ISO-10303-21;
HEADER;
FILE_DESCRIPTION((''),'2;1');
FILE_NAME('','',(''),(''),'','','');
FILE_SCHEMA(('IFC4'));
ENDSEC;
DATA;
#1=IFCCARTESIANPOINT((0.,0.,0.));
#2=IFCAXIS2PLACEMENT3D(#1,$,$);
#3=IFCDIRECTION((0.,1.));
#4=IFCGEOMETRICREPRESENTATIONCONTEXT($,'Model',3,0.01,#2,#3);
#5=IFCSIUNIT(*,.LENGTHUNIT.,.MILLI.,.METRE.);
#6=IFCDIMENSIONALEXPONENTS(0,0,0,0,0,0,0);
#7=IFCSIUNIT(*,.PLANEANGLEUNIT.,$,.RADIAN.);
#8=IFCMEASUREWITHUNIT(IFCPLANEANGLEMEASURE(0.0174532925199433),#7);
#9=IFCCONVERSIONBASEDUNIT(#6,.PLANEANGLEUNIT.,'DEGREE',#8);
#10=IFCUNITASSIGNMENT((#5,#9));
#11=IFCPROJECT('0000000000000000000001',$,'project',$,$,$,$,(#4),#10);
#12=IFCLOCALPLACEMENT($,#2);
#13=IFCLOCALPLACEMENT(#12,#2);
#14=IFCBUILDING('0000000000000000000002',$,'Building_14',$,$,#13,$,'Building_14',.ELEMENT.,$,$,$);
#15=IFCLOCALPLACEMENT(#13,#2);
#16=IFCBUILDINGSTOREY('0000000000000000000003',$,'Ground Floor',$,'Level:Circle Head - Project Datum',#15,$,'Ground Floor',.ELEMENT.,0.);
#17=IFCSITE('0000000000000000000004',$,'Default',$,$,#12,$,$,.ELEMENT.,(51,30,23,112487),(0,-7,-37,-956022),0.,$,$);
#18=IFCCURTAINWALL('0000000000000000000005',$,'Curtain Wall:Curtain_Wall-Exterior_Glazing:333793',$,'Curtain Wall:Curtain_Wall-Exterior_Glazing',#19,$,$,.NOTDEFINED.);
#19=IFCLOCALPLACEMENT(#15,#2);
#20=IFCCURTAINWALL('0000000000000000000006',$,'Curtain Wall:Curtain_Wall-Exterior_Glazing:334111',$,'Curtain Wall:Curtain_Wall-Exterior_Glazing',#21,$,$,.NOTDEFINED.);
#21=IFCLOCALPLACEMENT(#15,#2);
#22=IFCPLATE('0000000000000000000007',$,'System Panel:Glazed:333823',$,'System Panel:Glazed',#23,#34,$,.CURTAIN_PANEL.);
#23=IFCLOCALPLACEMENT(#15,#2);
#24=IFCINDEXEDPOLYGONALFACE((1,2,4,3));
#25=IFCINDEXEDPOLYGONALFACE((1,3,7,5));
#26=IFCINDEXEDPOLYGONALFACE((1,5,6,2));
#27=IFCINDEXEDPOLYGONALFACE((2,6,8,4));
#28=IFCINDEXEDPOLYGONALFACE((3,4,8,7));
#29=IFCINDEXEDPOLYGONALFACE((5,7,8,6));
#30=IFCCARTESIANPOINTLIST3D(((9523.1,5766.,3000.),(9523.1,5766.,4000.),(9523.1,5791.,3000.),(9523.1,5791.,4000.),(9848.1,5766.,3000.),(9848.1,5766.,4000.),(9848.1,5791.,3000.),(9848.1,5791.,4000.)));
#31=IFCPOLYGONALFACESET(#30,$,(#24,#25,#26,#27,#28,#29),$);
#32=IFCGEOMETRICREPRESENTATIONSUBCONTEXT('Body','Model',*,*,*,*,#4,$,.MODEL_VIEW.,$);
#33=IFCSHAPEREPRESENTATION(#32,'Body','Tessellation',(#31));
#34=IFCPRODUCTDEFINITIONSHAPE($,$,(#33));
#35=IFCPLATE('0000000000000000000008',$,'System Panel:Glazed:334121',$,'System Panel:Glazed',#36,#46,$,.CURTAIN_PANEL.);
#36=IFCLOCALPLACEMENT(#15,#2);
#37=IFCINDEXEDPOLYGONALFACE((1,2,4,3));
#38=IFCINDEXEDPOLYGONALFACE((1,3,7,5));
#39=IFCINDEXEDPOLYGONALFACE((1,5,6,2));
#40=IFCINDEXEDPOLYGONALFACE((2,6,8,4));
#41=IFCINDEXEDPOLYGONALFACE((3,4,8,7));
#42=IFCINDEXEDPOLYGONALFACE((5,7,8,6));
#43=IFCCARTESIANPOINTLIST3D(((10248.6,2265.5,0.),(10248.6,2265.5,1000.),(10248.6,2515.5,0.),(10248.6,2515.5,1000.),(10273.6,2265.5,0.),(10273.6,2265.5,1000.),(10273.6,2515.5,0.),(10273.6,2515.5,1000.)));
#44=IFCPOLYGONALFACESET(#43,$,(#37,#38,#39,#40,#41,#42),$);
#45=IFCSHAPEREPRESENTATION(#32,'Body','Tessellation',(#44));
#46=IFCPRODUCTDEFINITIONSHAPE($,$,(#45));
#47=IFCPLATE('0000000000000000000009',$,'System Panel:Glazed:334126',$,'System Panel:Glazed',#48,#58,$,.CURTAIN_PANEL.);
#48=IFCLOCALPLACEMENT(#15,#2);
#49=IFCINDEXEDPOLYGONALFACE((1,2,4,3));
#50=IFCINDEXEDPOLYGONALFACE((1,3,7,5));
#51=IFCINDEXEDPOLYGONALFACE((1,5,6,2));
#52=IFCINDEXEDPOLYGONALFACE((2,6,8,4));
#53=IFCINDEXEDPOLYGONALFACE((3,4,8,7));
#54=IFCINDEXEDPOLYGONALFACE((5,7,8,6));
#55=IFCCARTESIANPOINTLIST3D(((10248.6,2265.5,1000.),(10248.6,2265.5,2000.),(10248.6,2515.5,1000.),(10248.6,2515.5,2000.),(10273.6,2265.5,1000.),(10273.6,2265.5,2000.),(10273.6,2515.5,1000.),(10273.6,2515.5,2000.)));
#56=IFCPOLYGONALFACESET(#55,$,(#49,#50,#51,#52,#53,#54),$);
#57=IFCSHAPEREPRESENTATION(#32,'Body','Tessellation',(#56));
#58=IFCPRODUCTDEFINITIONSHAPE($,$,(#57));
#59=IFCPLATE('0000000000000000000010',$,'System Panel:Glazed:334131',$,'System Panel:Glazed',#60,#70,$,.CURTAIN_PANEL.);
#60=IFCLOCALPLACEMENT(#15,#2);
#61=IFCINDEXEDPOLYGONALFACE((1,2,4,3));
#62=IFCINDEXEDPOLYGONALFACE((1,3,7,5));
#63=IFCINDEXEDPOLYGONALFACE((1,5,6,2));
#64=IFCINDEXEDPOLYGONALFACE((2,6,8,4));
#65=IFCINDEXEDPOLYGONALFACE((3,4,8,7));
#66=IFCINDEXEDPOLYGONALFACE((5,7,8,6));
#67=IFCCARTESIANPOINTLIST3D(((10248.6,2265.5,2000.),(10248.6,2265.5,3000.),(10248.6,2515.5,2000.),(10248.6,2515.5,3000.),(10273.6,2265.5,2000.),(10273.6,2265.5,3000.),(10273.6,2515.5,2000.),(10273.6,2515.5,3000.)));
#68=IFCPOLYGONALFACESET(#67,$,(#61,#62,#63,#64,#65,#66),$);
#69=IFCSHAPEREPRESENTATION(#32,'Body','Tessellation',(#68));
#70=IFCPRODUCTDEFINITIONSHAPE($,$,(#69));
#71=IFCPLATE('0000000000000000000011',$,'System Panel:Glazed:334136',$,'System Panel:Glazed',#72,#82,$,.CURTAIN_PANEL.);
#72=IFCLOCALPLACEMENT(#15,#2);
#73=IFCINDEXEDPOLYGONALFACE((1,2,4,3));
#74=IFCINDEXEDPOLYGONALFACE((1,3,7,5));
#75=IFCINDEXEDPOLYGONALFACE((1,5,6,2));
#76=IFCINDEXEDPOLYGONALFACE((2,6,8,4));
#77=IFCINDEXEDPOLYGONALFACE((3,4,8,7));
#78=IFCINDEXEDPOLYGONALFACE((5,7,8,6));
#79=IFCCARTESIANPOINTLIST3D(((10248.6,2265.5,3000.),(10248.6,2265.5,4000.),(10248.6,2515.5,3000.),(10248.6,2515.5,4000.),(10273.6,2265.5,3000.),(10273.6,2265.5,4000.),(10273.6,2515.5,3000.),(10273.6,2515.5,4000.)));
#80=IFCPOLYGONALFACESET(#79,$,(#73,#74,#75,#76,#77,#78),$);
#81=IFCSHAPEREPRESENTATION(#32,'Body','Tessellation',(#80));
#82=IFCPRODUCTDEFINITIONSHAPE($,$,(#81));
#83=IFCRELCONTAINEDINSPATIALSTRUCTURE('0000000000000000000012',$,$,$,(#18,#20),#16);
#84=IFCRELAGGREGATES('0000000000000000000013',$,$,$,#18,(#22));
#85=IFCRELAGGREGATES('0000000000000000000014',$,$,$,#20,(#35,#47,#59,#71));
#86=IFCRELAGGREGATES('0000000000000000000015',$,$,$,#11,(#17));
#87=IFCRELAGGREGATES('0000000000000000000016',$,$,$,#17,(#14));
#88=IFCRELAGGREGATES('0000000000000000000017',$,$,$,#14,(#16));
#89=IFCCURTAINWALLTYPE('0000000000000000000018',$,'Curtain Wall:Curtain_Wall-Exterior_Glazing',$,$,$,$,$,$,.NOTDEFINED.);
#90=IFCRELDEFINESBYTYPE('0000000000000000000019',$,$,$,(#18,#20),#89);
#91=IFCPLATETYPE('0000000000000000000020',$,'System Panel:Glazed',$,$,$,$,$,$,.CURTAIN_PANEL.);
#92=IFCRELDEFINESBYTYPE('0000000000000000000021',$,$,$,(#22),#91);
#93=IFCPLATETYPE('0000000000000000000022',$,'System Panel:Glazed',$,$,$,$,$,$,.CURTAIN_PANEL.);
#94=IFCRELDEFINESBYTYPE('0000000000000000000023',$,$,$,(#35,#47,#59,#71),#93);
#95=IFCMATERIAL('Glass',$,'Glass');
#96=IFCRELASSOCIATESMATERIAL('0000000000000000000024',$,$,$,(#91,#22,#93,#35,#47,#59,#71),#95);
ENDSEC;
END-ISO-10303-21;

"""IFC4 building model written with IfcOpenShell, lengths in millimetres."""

from ifc_helpers import new_model, entity, si_unit, converted_unit, direction, frame, origin, place, context, subcontext, project, spatial, indexed_curve, outline, extrude, source, transform, mapped, material, type_object, type_shapes, element, aggregate, save


model = new_model("IFC4")

# Units and contexts
model_context = context("Model", 3, precision=0.01, world=origin(), true_north=direction((0.0, 1.0)))
body_context = subcontext(model_context, "Body", "Model", "MODEL_VIEW")
ifc_project = project(units=[si_unit("LENGTHUNIT", "METRE", prefix="MILLI"), converted_unit("PLANEANGLEUNIT", "DEGREE", entity("IfcPlaneAngleMeasure", 0.0174532925199433), si_unit("PLANEANGLEUNIT", "RADIAN"), dimensions=[0, 0, 0, 0, 0, 0, 0])], contexts=[model_context])

# Site, building, storey
site_placement = place(None, origin())
site = spatial("IfcSite", under=ifc_project, at=site_placement, Name="Default", CompositionType="ELEMENT", RefLatitude=(51, 30, 23, 112487), RefLongitude=(0, -7, -37, -956022), RefElevation=0.0)
building_placement = place(site_placement, origin())
building = spatial("IfcBuilding", under=site, at=building_placement, Name="Building_14", LongName="Building_14", CompositionType="ELEMENT")
storey_placement = place(building_placement, origin())
storey = spatial("IfcBuildingStorey", under=building, at=storey_placement, Name="Ground Floor", ObjectType="Level:Circle Head - Project Datum", LongName="Ground Floor", CompositionType="ELEMENT", Elevation=0.0)

# Curtain walls
curtain_wall_type = type_object("IfcCurtainWallType", Name="Curtain Wall:Curtain_Wall-Exterior_Glazing", PredefinedType="NOTDEFINED")
curtain_wall_1_placement = place(storey_placement, origin())
curtain_wall_1 = element("IfcCurtainWall", 1, at=curtain_wall_1_placement, inside=storey, type_object=curtain_wall_type, Name="Curtain Wall:Curtain_Wall-Exterior_Glazing:333793", ObjectType="Curtain Wall:Curtain_Wall-Exterior_Glazing", PredefinedType="NOTDEFINED")
ifc_material = material(Name="Glass", Category="Glass")
curtain_wall_2_placement = place(storey_placement, origin())
curtain_wall_2 = element("IfcCurtainWall", 2, at=curtain_wall_2_placement, inside=storey, type_object=curtain_wall_type, Name="Curtain Wall:Curtain_Wall-Exterior_Glazing:334111", ObjectType="Curtain Wall:Curtain_Wall-Exterior_Glazing", PredefinedType="NOTDEFINED")

# Plates
plate_type_1 = type_object("IfcPlateType", Name="System Panel:Glazed", PredefinedType="CURTAIN_PANEL", material=ifc_material)
shared_shape_1 = source(origin(), body_context, "Body", "SweptSolid", [
    extrude(outline(indexed_curve([(-12.5, -162.5), (12.5, -162.5), (12.5, 162.5), (-12.5, 162.5), (-12.5, -162.5)], self_intersect=False)), frame((0.0, -37.0, 0.0), z_axis=(0.0, 0.0, 1.0), x_axis=(0.0, 1.0, 0.0)), (0.0, 0.0, 1.0), 1000.0),
])
type_shapes(plate_type_1, [shared_shape_1])
plate_1_placement = place(curtain_wall_1_placement, frame((9685.6, 5815.5, 3000.0)))
plate_1 = element("IfcPlate", 3, at=plate_1_placement, type_object=plate_type_1, material=ifc_material, Name="System Panel:Glazed:333823", ObjectType="System Panel:Glazed", PredefinedType="CURTAIN_PANEL", context=body_context, shape_type="MappedRepresentation", body=[
    mapped(shared_shape_1, transform((0.0, 0.0, 0.0), scale=1.0)),
])
aggregate(curtain_wall_1, [plate_1])
plate_type_2 = type_object("IfcPlateType", Name="System Panel:Glazed", PredefinedType="CURTAIN_PANEL", material=ifc_material)
shared_shape_2 = source(origin(), body_context, "Body", "SweptSolid", [
    extrude(outline(indexed_curve([(-12.5, -125.0), (12.5, -125.0), (12.5, 125.0), (-12.5, 125.0), (-12.5, -125.0)], self_intersect=False)), frame((0.0, -37.0, 0.0), z_axis=(0.0, 0.0, 1.0), x_axis=(0.0, 1.0, 0.0)), (0.0, 0.0, 1.0), 1000.0),
])
type_shapes(plate_type_2, [shared_shape_2])
plate_2_placement = place(curtain_wall_2_placement, frame((10298.1, 2390.5, 0.0), z_axis=(0.0, 0.0, 1.0), x_axis=(0.0, -1.0, 0.0)))
plate_2 = element("IfcPlate", 4, at=plate_2_placement, type_object=plate_type_2, material=ifc_material, Name="System Panel:Glazed:334121", ObjectType="System Panel:Glazed", PredefinedType="CURTAIN_PANEL", context=body_context, shape_type="MappedRepresentation", body=[
    mapped(shared_shape_2, transform((0.0, 0.0, 0.0), scale=1.0)),
])
plate_3_placement = place(curtain_wall_2_placement, frame((10298.1, 2390.5, 1000.0), z_axis=(0.0, 0.0, 1.0), x_axis=(0.0, -1.0, 0.0)))
plate_3 = element("IfcPlate", 5, at=plate_3_placement, type_object=plate_type_2, material=ifc_material, Name="System Panel:Glazed:334126", ObjectType="System Panel:Glazed", PredefinedType="CURTAIN_PANEL", context=body_context, shape_type="MappedRepresentation", body=[
    mapped(shared_shape_2, transform((0.0, 0.0, 0.0), scale=1.0)),
])
plate_4_placement = place(curtain_wall_2_placement, frame((10298.1, 2390.5, 2000.0), z_axis=(0.0, 0.0, 1.0), x_axis=(0.0, -1.0, 0.0)))
plate_4 = element("IfcPlate", 6, at=plate_4_placement, type_object=plate_type_2, material=ifc_material, Name="System Panel:Glazed:334131", ObjectType="System Panel:Glazed", PredefinedType="CURTAIN_PANEL", context=body_context, shape_type="MappedRepresentation", body=[
    mapped(shared_shape_2, transform((0.0, 0.0, 0.0), scale=1.0)),
])
plate_5_placement = place(curtain_wall_2_placement, frame((10298.1, 2390.5, 3000.0), z_axis=(0.0, 0.0, 1.0), x_axis=(0.0, -1.0, 0.0)))
plate_5 = element("IfcPlate", 7, at=plate_5_placement, type_object=plate_type_2, material=ifc_material, Name="System Panel:Glazed:334136", ObjectType="System Panel:Glazed", PredefinedType="CURTAIN_PANEL", context=body_context, shape_type="MappedRepresentation", body=[
    mapped(shared_shape_2, transform((0.0, 0.0, 0.0), scale=1.0)),
])
aggregate(curtain_wall_2, [plate_2, plate_3, plate_4, plate_5])

save(model, "model.ifc")
